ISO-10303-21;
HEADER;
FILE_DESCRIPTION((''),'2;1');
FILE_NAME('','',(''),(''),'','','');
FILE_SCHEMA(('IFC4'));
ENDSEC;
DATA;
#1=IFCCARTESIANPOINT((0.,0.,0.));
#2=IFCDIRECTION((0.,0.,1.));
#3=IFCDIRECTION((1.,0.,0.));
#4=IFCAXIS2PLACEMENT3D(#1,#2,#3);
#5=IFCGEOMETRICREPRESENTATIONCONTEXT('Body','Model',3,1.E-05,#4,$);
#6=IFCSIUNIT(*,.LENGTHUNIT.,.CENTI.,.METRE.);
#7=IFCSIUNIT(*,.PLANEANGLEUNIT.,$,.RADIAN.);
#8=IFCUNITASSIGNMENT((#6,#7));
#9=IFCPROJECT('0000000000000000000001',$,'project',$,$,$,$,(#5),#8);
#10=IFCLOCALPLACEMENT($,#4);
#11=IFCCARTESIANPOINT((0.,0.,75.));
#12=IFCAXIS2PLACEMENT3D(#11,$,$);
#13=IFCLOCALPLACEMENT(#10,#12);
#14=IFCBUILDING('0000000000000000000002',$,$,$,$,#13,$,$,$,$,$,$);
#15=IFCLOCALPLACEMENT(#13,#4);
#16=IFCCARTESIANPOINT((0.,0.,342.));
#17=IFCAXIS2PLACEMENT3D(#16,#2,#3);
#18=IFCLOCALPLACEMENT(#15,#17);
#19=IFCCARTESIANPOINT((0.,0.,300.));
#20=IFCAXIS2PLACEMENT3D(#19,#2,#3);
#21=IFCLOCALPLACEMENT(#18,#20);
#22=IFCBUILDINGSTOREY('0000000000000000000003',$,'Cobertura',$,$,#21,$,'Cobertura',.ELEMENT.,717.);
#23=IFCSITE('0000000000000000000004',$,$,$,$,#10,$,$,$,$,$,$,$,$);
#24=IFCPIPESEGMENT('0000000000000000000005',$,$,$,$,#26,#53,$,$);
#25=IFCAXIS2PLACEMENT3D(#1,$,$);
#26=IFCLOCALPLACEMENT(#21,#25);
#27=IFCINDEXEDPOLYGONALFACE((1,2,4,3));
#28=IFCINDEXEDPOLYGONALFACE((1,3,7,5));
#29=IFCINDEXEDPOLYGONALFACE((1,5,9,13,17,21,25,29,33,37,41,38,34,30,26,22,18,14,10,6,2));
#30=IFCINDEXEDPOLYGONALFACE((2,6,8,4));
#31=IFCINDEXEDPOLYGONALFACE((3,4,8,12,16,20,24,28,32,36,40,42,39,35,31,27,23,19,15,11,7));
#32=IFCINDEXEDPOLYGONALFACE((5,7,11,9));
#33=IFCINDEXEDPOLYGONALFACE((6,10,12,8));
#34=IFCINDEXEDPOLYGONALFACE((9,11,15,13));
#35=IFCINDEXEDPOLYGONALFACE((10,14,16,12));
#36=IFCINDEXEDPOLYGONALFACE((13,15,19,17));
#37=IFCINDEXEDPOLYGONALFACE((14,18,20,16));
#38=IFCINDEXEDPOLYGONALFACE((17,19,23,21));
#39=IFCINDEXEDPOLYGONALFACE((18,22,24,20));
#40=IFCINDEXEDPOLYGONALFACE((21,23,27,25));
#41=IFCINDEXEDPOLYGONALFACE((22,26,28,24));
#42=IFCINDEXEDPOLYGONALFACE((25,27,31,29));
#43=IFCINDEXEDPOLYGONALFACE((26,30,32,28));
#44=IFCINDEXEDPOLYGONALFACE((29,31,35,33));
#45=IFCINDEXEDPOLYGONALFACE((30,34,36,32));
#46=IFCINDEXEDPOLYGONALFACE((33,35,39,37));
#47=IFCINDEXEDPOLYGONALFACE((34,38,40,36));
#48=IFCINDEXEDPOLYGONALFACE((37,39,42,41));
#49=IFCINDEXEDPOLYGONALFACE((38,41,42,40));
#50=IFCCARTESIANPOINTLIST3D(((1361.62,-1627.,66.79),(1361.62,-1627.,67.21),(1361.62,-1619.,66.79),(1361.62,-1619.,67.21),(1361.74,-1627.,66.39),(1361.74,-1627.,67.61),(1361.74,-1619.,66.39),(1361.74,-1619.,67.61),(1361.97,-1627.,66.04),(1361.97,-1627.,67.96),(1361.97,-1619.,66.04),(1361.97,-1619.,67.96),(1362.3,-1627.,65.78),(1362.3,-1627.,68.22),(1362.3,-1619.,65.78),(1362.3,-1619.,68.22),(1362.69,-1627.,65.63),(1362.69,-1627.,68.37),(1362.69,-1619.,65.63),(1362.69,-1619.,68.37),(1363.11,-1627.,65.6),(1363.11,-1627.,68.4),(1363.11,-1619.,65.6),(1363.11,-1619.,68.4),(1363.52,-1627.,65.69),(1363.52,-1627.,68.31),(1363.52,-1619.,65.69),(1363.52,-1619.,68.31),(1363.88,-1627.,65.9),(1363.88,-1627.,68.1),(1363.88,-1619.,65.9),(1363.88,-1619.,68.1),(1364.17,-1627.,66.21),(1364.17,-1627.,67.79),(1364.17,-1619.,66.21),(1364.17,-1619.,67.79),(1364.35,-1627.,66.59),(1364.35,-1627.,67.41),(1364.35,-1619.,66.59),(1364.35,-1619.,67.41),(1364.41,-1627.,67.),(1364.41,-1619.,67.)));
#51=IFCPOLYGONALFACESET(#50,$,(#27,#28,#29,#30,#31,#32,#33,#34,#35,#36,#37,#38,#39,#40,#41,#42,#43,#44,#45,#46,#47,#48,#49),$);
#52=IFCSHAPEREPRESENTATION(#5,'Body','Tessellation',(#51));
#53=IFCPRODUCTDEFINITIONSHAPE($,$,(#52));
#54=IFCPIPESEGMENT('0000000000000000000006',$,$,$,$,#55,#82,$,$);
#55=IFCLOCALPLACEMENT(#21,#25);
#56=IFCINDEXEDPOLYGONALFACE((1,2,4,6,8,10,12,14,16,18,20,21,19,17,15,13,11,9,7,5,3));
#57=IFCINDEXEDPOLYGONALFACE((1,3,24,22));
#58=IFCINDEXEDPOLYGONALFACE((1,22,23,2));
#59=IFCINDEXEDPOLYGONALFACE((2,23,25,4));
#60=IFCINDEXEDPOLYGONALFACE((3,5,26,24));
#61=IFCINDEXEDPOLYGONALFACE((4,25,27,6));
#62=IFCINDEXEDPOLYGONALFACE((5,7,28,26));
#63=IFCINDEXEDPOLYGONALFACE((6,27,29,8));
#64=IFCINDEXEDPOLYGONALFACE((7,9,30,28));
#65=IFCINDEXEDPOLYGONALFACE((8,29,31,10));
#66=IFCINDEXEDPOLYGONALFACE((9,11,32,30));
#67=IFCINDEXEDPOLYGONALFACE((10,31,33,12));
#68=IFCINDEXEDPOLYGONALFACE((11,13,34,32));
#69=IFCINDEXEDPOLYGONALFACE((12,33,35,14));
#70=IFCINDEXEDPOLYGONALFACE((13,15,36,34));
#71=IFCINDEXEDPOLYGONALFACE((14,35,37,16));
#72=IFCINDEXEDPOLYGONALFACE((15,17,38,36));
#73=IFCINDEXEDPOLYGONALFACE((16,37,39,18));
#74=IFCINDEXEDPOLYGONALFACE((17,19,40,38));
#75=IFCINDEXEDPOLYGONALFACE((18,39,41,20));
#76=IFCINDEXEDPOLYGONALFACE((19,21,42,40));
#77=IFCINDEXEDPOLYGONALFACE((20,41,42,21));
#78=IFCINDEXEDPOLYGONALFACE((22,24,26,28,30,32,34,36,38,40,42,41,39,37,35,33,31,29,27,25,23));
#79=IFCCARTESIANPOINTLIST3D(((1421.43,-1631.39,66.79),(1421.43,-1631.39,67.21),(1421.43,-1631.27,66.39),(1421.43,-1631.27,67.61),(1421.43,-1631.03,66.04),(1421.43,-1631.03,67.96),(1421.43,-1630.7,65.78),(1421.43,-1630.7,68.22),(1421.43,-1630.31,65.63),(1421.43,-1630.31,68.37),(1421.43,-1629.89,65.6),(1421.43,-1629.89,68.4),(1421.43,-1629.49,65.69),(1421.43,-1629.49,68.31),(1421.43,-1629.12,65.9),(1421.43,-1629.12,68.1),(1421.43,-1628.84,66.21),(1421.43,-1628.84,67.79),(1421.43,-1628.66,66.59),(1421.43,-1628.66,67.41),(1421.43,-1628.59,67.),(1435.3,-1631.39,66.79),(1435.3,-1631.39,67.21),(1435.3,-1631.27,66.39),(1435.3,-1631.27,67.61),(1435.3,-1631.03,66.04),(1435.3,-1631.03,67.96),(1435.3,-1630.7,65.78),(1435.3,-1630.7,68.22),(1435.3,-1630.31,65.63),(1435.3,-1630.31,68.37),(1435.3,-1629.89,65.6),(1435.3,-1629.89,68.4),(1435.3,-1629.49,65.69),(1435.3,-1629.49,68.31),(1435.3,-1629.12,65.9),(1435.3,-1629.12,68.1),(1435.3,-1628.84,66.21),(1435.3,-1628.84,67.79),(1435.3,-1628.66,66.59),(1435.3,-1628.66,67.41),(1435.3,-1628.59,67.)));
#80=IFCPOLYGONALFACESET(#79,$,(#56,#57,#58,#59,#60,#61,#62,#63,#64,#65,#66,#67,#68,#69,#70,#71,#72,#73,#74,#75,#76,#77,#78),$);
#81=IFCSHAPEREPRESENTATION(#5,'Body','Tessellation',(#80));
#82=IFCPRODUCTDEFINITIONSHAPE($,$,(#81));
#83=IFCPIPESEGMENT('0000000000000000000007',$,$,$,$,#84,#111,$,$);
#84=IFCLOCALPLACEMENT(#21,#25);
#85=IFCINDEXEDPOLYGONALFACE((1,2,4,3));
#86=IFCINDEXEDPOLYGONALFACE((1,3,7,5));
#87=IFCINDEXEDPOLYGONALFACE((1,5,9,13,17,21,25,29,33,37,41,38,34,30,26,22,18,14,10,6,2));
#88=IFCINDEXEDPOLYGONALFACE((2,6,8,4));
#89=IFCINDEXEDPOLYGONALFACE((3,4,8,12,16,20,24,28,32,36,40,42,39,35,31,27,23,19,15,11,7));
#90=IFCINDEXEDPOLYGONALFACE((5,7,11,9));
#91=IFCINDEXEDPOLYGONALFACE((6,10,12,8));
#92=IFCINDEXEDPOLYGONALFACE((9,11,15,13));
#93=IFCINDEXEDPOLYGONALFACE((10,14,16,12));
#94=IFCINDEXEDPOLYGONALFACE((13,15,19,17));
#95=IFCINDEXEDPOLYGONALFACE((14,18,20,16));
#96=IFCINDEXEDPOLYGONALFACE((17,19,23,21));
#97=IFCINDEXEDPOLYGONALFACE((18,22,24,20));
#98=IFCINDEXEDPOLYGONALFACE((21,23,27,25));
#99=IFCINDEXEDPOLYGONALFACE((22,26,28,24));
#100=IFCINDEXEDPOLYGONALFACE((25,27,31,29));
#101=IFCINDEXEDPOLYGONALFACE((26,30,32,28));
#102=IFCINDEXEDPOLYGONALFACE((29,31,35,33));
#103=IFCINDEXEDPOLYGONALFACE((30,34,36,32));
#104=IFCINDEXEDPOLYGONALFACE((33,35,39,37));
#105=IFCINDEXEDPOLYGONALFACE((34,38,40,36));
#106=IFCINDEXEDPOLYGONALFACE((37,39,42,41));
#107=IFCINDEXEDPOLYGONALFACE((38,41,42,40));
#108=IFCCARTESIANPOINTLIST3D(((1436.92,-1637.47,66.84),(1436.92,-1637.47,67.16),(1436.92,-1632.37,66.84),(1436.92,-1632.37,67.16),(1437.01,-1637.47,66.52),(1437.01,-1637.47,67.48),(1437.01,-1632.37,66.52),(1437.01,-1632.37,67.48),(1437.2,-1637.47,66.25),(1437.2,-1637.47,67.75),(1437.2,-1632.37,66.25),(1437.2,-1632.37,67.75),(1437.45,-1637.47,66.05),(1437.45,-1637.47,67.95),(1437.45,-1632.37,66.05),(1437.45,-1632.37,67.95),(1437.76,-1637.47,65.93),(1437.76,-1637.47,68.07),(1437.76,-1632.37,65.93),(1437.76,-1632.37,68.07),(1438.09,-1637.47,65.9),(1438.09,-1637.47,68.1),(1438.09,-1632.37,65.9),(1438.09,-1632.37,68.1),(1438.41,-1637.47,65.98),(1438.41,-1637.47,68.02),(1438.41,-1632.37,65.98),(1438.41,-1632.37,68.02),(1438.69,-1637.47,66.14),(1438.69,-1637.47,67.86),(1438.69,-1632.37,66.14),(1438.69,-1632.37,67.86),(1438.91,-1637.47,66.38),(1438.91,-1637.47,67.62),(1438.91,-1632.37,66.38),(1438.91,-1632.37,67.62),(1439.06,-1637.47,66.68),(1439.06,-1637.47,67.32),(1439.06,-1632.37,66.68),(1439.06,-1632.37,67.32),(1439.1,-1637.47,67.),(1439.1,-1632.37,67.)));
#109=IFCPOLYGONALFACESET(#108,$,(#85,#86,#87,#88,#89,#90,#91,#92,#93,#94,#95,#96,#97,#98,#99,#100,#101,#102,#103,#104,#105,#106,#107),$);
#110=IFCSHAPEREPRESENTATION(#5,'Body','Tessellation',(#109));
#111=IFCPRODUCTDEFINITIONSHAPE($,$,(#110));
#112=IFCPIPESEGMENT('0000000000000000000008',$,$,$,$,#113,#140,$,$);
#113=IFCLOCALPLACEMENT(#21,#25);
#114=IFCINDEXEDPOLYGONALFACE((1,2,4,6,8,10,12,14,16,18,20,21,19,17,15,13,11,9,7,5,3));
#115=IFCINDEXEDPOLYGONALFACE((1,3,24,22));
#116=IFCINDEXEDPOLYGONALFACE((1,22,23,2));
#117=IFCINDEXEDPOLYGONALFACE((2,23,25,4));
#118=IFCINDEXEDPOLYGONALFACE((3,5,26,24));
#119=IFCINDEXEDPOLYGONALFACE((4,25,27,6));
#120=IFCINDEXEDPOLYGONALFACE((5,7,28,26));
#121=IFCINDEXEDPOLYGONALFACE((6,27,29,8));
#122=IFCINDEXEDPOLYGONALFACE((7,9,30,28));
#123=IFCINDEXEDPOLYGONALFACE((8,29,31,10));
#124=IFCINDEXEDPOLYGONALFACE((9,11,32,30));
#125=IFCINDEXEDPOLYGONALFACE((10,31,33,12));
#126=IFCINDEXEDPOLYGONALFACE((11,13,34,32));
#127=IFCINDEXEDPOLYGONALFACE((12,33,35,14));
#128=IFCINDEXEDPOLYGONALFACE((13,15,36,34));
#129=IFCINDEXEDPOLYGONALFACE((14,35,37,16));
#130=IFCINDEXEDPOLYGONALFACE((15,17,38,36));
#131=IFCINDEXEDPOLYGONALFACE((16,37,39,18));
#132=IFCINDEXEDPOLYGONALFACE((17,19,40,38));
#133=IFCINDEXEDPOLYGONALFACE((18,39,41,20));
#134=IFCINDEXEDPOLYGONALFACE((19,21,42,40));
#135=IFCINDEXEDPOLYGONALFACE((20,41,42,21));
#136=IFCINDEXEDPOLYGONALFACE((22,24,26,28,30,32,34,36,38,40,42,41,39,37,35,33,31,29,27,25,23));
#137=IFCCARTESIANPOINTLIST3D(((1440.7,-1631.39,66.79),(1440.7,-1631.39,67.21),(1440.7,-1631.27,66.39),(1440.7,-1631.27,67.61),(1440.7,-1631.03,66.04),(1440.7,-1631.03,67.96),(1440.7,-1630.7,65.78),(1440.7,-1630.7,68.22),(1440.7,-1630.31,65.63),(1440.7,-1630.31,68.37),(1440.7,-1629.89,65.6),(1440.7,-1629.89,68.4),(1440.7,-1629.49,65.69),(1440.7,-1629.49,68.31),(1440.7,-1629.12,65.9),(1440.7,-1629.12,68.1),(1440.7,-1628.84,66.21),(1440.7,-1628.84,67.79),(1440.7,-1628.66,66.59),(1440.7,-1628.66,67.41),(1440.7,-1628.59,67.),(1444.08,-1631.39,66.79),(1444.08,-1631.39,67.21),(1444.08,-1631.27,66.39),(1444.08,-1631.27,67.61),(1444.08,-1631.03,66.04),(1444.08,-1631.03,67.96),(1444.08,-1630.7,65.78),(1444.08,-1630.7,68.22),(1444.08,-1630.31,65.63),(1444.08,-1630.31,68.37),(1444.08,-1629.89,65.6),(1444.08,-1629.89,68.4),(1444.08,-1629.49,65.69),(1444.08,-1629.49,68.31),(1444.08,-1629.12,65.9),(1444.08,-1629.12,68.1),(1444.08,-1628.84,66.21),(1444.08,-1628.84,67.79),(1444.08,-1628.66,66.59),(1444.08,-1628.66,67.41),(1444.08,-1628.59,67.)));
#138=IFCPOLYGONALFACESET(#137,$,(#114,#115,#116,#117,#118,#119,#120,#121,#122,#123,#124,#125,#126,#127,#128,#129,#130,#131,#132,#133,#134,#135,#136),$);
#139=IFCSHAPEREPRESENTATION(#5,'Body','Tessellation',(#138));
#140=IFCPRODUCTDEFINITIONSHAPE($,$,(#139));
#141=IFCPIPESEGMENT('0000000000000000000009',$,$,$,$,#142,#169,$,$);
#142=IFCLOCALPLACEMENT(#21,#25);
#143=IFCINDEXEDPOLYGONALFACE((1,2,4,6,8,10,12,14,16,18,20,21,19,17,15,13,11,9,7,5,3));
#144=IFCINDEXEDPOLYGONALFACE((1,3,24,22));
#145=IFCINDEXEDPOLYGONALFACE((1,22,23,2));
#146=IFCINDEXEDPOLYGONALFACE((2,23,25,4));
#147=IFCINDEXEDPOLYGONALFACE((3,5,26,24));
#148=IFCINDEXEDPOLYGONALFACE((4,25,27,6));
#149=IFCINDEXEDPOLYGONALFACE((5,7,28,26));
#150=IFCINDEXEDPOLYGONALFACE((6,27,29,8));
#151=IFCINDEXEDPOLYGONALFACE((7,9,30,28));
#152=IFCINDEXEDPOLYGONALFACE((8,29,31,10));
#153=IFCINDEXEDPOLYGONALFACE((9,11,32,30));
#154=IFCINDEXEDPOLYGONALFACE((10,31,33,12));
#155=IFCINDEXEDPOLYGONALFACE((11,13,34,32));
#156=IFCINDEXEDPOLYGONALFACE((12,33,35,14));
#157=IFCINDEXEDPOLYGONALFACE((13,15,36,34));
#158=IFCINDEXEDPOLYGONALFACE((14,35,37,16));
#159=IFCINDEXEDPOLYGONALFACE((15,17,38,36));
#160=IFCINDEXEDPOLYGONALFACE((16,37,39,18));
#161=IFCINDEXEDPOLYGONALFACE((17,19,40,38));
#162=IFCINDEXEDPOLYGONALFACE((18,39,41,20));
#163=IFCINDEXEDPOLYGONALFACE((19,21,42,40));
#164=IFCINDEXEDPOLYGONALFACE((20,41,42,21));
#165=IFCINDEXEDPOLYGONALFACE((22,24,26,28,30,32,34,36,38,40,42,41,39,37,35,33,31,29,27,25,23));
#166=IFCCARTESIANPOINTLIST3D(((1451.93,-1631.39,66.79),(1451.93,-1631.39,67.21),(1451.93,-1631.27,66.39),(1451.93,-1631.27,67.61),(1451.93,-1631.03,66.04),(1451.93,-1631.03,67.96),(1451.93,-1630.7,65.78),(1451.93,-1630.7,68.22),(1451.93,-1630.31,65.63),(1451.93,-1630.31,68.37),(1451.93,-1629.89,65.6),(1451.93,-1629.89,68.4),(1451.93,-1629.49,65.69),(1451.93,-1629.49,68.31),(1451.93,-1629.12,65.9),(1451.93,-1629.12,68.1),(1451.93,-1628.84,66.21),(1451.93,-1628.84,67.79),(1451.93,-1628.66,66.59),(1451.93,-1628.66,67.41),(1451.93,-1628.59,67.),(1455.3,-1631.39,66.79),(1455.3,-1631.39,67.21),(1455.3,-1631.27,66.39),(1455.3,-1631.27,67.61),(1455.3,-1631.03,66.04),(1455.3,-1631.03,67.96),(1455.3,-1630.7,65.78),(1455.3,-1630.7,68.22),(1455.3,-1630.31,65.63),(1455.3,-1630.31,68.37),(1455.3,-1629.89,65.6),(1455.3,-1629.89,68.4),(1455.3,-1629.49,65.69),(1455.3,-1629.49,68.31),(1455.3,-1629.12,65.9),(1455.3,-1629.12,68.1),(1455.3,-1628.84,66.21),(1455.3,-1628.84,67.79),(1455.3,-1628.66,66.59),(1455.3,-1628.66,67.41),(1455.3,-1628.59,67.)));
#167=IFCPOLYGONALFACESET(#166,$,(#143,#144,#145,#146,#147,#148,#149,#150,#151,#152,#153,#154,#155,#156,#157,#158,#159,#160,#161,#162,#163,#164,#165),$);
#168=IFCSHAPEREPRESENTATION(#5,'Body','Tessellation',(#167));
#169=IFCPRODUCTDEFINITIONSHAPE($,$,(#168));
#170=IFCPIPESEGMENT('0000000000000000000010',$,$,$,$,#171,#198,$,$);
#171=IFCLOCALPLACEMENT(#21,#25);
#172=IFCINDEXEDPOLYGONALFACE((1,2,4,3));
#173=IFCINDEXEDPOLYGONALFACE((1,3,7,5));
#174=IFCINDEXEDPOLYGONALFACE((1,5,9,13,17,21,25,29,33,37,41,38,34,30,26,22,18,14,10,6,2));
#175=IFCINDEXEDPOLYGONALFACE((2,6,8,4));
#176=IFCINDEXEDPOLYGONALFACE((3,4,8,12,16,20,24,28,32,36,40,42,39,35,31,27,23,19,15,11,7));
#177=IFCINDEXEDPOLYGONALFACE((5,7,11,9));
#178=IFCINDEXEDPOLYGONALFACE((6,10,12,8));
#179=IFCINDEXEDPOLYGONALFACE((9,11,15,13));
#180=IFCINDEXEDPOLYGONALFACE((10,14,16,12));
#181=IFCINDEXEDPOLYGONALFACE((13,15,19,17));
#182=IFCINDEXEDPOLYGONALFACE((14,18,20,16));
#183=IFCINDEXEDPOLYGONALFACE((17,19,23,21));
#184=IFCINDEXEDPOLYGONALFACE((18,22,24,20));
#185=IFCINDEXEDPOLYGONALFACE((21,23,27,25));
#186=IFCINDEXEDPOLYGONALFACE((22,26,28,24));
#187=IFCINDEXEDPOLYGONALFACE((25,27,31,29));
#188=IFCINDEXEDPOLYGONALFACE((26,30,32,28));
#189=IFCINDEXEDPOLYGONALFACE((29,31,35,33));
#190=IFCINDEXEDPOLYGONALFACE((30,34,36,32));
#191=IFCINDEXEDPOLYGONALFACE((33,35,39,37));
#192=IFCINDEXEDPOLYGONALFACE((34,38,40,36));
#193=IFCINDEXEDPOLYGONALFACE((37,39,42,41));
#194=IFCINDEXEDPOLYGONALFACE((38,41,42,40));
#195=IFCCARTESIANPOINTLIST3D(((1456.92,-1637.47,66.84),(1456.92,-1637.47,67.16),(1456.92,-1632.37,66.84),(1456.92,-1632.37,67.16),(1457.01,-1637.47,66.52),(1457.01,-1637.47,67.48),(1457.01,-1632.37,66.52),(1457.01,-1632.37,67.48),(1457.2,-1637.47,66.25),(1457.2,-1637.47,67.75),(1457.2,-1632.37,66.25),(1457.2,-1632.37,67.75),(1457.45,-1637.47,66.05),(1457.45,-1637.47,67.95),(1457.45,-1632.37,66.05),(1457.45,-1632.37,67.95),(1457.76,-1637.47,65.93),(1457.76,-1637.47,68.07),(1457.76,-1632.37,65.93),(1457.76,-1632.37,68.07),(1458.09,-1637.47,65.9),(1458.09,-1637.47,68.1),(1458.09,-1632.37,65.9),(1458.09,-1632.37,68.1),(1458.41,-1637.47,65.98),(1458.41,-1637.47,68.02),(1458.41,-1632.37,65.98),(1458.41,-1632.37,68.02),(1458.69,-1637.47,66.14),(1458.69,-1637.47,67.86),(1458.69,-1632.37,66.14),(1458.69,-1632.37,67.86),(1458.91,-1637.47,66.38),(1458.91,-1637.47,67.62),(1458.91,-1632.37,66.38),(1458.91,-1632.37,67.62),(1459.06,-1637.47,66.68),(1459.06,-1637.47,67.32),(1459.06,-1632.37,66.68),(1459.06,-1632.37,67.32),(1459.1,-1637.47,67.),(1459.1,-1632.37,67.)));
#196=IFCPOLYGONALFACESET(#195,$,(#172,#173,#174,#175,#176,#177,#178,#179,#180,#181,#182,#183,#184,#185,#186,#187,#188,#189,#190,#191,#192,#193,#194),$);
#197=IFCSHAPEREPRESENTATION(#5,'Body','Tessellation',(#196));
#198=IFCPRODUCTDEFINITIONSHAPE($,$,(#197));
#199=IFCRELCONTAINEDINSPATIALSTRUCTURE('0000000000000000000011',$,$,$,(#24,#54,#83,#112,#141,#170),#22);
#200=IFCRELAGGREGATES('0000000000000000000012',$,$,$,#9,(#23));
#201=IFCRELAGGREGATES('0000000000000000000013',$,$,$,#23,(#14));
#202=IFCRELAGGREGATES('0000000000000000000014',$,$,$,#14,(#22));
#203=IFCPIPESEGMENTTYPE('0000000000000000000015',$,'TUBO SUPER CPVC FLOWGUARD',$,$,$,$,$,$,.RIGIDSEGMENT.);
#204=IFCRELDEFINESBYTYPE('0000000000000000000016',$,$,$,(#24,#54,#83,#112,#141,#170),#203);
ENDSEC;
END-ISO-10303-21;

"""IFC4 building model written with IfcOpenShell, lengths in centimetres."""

from ifc_helpers import new_model, si_unit, frame, origin_with_axes, origin_2d_with_axis, place, context, project, spatial, circle, extrude, type_object, element, save


model = new_model("IFC4")

# Units and contexts
model_context = context("Model", 3, precision=1e-05, world=origin_with_axes(), identifier="Body")
ifc_project = project(units=[si_unit("LENGTHUNIT", "METRE", prefix="CENTI"), si_unit("PLANEANGLEUNIT", "RADIAN")], contexts=[model_context])

# Site, building, storey
site_placement = place(None, origin_with_axes())
site = spatial("IfcSite", under=ifc_project, at=site_placement)
building_placement = place(site_placement, frame((0.0, 0.0, 75.0)))
building = spatial("IfcBuilding", under=site, at=building_placement)
placement_1 = place(building_placement, origin_with_axes())
placement_2 = place(placement_1, frame((0.0, 0.0, 342.0), z_axis=(0.0, 0.0, 1.0), x_axis=(1.0, 0.0, 0.0)))
storey_placement = place(placement_2, frame((0.0, 0.0, 300.0), z_axis=(0.0, 0.0, 1.0), x_axis=(1.0, 0.0, 0.0)))
storey = spatial("IfcBuildingStorey", under=building, at=storey_placement, Name="Cobertura", LongName="Cobertura", CompositionType="ELEMENT", Elevation=717.0)

# Pipe segments
pipe_segment_type_1 = type_object("IfcPipeSegmentType", Name="TUBO SUPER CPVC FLOWGUARD", PredefinedType="RIGIDSEGMENT")
pipe_segment_1_placement = place(storey_placement, frame((1363.0, -1623.0, 68.41), z_axis=(0.0, 0.0, 1.0), x_axis=(1.0, 0.0, 0.0)))
element("IfcPipeSegment", 1, at=pipe_segment_1_placement, inside=storey, type_object=pipe_segment_type_1, context=model_context, shape_type="SolidModel", body=[
    extrude(circle(Radius=1.41, at=origin_2d_with_axis()), frame((0.0, 4.0, -1.41), z_axis=(0.0, -1.0, 0.0), x_axis=(1.0, 0.0, 0.0)), (0.0, 0.0, 1.0), 8.0),
])
pipe_segment_2_placement = place(storey_placement, frame((1428.37, -1630.0, 68.41), z_axis=(0.0, 0.0, 1.0), x_axis=(1.0, 0.0, 0.0)))
element("IfcPipeSegment", 2, at=pipe_segment_2_placement, inside=storey, type_object=pipe_segment_type_1, context=model_context, shape_type="SolidModel", body=[
    extrude(circle(Radius=1.41, at=origin_2d_with_axis()), frame((-6.93, 0.0, -1.41), z_axis=(1.0, 0.0, 0.0), x_axis=(0.0, 1.0, 0.0)), (0.0, 0.0, 1.0), 13.87),
])
pipe_segment_3_placement = place(storey_placement, frame((1438.0, -1634.92, 68.1), z_axis=(0.0, 0.0, 1.0), x_axis=(1.0, 0.0, 0.0)))
element("IfcPipeSegment", 3, at=pipe_segment_3_placement, inside=storey, type_object=pipe_segment_type_1, context=model_context, shape_type="SolidModel", body=[
    extrude(circle(Radius=1.1, at=origin_2d_with_axis()), frame((0.0, 2.55, -1.1), z_axis=(0.0, -1.0, 0.0), x_axis=(1.0, 0.0, 0.0)), (0.0, 0.0, 1.0), 5.1),
])
pipe_segment_4_placement = place(storey_placement, frame((1442.39, -1630.0, 68.41), z_axis=(0.0, 0.0, 1.0), x_axis=(1.0, 0.0, 0.0)))
element("IfcPipeSegment", 4, at=pipe_segment_4_placement, inside=storey, type_object=pipe_segment_type_1, context=model_context, shape_type="SolidModel", body=[
    extrude(circle(Radius=1.41, at=origin_2d_with_axis()), frame((-1.69, 0.0, -1.41), z_axis=(1.0, 0.0, 0.0), x_axis=(0.0, 1.0, 0.0)), (0.0, 0.0, 1.0), 3.37),
])
pipe_segment_5_placement = place(storey_placement, frame((1453.62, -1630.0, 68.41), z_axis=(0.0, 0.0, 1.0), x_axis=(1.0, 0.0, 0.0)))
element("IfcPipeSegment", 5, at=pipe_segment_5_placement, inside=storey, type_object=pipe_segment_type_1, context=model_context, shape_type="SolidModel", body=[
    extrude(circle(Radius=1.41, at=origin_2d_with_axis()), frame((-1.69, 0.0, -1.41), z_axis=(1.0, 0.0, 0.0), x_axis=(0.0, 1.0, 0.0)), (0.0, 0.0, 1.0), 3.37),
])
pipe_segment_6_placement = place(storey_placement, frame((1458.0, -1634.92, 68.1), z_axis=(0.0, 0.0, 1.0), x_axis=(1.0, 0.0, 0.0)))
element("IfcPipeSegment", 6, at=pipe_segment_6_placement, inside=storey, type_object=pipe_segment_type_1, context=model_context, shape_type="SolidModel", body=[
    extrude(circle(Radius=1.1, at=origin_2d_with_axis()), frame((0.0, 2.55, -1.1), z_axis=(0.0, -1.0, 0.0), x_axis=(1.0, 0.0, 0.0)), (0.0, 0.0, 1.0), 5.1),
])

save(model, "model.ifc")
